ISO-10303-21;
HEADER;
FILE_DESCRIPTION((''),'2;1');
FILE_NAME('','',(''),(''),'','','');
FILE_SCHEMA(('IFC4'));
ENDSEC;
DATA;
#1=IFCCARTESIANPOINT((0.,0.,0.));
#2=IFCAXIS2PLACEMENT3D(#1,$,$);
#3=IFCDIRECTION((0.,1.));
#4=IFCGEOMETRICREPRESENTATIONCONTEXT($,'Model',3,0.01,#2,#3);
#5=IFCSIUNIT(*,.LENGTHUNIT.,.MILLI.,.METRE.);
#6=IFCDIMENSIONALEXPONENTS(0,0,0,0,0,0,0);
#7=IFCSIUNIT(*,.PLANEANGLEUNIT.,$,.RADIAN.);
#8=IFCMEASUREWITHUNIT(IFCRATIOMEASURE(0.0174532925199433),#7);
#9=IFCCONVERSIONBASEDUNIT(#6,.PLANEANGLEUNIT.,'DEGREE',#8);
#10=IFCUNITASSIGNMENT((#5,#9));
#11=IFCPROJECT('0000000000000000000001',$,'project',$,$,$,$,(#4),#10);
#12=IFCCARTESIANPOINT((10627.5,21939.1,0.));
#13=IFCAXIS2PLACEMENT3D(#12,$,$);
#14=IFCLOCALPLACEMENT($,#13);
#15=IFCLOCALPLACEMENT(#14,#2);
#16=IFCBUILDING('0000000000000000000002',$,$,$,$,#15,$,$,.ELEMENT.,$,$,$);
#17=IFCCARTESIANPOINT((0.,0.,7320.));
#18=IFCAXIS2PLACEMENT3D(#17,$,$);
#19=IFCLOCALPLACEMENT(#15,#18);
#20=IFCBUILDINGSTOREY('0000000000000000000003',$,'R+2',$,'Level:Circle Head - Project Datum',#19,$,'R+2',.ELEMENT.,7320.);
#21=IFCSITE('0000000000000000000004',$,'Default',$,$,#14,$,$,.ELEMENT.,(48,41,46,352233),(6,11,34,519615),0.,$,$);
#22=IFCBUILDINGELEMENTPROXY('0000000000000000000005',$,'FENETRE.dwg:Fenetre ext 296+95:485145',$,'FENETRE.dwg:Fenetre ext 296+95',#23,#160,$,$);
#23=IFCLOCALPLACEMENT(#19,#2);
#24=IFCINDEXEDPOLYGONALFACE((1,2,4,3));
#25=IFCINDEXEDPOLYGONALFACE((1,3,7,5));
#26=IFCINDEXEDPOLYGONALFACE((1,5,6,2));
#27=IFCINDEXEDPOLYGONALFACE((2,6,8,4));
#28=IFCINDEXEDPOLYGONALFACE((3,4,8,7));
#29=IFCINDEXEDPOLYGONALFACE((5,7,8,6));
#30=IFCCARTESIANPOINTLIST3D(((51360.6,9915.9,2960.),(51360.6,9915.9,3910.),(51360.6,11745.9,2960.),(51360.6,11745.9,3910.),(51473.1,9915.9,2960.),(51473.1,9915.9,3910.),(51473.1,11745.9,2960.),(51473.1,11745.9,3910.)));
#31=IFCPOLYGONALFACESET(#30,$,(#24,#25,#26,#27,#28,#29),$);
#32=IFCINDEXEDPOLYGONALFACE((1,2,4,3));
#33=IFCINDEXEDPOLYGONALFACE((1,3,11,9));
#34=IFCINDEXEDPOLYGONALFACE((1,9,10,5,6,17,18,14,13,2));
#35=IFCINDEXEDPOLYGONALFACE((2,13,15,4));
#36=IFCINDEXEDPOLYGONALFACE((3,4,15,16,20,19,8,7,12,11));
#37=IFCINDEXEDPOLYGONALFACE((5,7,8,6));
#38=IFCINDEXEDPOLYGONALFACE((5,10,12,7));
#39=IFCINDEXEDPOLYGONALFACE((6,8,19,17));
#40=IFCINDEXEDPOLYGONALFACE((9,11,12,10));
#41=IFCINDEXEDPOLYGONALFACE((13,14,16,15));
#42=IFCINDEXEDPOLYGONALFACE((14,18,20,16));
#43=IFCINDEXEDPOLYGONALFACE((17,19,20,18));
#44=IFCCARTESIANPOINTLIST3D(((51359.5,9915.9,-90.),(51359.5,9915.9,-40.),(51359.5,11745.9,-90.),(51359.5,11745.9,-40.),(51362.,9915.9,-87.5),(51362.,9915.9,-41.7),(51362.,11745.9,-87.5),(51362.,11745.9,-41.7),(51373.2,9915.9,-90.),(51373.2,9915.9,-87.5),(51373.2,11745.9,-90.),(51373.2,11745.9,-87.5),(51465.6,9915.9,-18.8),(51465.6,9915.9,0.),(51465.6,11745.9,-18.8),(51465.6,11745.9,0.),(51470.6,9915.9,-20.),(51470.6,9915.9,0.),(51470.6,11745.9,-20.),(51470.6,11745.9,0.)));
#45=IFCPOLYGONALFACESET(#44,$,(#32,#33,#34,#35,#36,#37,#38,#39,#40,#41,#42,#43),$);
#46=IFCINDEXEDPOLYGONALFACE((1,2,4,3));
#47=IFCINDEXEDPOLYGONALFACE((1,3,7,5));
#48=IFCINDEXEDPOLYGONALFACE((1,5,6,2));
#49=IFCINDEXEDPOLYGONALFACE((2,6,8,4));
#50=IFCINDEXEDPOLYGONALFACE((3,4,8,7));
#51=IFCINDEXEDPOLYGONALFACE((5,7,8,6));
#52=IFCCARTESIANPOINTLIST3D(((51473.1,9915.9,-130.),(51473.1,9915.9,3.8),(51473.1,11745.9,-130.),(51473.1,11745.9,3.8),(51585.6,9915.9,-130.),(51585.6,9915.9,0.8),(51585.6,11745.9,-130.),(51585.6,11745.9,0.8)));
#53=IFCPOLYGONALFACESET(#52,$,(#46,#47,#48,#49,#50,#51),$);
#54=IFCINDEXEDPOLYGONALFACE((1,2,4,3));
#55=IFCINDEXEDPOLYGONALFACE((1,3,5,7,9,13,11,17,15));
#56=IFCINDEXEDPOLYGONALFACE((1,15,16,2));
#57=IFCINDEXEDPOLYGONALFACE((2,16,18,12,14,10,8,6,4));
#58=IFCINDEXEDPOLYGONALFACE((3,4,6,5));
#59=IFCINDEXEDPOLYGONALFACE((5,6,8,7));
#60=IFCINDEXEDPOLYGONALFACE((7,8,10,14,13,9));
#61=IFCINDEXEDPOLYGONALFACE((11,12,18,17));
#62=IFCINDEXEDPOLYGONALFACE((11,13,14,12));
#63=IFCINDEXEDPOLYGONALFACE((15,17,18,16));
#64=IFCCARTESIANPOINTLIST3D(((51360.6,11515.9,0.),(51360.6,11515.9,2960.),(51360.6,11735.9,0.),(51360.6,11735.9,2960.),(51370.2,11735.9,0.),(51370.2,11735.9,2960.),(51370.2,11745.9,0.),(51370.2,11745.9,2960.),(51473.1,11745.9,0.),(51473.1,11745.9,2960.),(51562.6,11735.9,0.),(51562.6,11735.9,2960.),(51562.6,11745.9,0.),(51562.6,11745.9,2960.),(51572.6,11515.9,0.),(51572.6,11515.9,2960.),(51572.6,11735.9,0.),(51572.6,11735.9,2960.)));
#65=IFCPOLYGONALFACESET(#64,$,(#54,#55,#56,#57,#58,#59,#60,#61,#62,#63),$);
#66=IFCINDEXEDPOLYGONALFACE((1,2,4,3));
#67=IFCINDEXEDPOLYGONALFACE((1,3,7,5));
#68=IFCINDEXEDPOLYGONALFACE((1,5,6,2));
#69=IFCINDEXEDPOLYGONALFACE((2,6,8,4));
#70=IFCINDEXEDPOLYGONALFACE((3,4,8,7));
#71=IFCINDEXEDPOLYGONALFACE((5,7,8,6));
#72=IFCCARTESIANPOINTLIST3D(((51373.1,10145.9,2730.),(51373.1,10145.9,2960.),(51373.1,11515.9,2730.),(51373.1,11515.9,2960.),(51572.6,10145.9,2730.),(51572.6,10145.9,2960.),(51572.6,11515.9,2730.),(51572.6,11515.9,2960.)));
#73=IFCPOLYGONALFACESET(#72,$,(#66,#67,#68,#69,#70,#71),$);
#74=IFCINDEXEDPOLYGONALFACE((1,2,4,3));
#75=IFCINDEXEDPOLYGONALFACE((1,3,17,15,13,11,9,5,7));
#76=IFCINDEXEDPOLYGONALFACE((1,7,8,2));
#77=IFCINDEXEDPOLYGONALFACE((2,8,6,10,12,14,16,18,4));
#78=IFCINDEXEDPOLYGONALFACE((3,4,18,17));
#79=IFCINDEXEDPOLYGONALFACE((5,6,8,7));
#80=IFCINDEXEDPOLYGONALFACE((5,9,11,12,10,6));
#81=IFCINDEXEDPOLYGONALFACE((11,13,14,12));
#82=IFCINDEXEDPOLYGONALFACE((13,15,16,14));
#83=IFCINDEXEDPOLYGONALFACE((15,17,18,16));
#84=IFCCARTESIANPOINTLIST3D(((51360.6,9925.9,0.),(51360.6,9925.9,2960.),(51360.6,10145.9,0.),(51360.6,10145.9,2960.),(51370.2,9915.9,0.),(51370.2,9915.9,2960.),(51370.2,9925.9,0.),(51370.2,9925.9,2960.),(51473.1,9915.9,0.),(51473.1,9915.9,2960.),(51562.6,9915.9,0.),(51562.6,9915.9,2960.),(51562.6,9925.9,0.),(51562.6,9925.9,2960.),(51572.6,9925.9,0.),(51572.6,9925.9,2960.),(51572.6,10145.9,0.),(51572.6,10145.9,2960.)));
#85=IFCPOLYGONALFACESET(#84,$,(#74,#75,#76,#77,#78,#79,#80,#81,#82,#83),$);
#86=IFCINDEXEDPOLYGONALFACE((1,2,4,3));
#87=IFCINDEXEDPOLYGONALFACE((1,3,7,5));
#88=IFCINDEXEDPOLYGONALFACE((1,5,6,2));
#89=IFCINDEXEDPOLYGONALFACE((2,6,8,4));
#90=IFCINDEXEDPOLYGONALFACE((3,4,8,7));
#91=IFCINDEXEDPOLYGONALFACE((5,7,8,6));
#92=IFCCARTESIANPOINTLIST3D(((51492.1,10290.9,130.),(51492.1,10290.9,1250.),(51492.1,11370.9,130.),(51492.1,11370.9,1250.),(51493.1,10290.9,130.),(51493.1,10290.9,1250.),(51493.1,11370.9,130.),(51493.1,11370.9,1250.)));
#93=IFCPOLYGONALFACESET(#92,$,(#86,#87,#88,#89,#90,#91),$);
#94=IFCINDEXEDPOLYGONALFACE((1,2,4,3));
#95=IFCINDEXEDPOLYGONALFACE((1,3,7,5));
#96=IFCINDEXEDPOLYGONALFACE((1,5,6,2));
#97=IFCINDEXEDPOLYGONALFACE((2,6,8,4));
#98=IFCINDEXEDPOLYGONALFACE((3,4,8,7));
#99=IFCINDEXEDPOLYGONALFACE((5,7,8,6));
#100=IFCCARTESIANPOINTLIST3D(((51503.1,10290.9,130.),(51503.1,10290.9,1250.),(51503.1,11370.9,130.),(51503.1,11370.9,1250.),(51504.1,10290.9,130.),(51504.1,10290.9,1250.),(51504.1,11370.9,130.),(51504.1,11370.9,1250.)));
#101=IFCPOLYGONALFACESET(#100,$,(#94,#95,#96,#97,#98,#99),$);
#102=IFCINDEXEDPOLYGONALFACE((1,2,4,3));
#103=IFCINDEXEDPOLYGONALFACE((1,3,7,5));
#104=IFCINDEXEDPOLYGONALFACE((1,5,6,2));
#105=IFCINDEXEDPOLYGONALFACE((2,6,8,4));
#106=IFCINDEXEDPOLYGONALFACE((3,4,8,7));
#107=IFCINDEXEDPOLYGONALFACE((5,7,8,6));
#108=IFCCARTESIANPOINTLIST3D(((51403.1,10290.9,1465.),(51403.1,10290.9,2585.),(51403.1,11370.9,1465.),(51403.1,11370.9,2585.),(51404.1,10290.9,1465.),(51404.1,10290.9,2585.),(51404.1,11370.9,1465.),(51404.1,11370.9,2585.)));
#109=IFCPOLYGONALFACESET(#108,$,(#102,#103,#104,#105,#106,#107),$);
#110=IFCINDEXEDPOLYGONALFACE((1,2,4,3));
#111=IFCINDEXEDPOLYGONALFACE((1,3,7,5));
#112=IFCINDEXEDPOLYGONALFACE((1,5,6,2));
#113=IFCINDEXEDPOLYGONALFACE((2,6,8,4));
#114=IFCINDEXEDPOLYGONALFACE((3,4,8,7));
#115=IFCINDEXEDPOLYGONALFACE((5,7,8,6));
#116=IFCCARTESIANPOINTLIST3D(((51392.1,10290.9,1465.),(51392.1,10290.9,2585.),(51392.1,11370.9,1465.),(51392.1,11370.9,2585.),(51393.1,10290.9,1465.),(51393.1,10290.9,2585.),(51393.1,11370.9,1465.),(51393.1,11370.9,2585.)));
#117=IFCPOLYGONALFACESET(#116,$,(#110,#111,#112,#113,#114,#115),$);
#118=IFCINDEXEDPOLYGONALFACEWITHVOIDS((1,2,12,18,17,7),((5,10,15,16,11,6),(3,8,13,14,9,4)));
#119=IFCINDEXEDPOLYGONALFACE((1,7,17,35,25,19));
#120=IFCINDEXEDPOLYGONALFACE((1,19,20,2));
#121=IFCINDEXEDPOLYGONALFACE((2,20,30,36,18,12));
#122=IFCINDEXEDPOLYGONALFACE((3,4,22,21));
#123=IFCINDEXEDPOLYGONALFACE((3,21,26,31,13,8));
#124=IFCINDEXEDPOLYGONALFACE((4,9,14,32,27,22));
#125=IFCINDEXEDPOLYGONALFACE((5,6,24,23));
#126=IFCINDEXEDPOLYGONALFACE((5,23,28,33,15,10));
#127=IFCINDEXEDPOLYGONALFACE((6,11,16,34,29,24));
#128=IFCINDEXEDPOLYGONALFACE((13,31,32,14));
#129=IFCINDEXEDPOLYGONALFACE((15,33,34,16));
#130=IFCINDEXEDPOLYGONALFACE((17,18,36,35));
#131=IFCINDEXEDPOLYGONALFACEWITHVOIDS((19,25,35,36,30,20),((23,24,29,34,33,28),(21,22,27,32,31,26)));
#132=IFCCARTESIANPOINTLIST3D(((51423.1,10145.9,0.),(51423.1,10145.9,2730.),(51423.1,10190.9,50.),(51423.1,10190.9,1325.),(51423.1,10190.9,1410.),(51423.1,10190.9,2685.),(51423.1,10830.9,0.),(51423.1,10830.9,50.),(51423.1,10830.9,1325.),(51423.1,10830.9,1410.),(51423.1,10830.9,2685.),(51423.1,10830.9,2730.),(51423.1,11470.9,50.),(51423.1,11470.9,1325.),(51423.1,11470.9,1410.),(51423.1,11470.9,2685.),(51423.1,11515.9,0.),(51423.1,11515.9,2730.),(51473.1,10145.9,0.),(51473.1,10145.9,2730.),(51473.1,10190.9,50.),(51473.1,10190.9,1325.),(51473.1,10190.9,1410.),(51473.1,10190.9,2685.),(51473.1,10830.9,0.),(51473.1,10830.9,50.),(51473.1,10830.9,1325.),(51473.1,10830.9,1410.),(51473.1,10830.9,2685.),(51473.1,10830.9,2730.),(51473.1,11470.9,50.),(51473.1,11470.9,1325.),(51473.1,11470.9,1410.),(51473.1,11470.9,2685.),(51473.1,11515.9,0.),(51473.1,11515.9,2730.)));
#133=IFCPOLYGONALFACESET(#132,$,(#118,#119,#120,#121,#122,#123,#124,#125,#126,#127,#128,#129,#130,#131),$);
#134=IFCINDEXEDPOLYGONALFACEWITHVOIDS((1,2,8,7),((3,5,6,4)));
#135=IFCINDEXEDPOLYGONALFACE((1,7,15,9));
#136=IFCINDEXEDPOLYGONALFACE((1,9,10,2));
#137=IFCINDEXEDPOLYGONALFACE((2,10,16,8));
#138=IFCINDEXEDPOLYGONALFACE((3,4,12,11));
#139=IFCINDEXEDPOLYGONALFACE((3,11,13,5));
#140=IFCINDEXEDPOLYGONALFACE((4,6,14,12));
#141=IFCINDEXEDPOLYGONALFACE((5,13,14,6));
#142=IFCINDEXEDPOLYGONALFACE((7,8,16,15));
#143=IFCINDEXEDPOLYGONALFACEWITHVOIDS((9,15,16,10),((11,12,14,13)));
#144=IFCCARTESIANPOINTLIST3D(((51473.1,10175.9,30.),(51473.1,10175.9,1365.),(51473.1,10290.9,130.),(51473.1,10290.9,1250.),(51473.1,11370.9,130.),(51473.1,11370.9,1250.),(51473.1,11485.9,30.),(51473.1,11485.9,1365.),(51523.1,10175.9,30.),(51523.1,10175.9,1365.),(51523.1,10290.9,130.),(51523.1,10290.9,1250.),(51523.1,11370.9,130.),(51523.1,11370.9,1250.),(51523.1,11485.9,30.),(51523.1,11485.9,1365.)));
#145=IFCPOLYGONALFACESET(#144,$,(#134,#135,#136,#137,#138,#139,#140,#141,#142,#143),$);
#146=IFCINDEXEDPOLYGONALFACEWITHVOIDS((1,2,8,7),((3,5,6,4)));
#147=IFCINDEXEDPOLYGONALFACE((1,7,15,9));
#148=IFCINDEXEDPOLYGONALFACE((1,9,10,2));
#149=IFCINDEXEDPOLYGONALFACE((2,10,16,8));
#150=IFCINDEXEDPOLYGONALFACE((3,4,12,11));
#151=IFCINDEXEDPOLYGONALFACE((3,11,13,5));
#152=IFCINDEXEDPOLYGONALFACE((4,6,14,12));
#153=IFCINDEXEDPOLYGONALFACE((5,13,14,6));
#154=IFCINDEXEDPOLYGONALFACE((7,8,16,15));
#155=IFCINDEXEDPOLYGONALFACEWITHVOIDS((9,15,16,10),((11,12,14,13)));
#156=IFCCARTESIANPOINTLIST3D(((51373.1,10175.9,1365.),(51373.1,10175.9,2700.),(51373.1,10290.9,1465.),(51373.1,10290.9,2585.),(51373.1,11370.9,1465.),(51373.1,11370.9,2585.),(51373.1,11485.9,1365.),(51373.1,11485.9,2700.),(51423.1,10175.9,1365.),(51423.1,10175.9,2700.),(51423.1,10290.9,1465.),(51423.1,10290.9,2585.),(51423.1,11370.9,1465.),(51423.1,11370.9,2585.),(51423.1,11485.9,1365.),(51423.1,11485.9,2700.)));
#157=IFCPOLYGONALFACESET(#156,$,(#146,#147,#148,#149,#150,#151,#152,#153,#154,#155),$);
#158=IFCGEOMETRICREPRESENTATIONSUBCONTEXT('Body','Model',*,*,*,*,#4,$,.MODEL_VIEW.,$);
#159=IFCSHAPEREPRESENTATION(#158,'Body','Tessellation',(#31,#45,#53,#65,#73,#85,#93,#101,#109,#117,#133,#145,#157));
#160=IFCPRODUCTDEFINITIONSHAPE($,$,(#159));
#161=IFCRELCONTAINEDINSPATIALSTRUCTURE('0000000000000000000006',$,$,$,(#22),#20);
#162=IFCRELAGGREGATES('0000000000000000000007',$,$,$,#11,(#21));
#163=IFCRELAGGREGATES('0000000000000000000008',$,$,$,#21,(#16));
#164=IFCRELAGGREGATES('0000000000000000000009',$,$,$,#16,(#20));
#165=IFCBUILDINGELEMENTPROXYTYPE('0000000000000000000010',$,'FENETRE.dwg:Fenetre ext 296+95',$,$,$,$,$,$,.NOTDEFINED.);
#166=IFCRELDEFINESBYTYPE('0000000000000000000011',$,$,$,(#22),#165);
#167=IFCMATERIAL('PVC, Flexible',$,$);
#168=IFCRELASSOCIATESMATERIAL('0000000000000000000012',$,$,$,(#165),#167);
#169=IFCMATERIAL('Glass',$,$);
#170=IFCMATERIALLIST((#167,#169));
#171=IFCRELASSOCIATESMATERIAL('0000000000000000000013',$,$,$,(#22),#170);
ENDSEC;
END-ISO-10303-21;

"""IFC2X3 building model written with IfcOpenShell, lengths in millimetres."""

from ifc_helpers import new_model, entity, si_unit, converted_unit, direction, frame, frame_2d, origin, origin_2d_with_axis, place, context, subcontext, project, spatial, polyline, rectangle, outline, extrude, source, transform, mapped, material, material_list, type_object, type_shapes, element, save


model = new_model("IFC2X3")

# Units and contexts
model_context = context("Model", 3, precision=0.01, world=origin(), true_north=direction((0.0, 1.0)))
body_context = subcontext(model_context, "Body", "Model", "MODEL_VIEW")
ifc_project = project(units=[si_unit("LENGTHUNIT", "METRE", prefix="MILLI"), converted_unit("PLANEANGLEUNIT", "DEGREE", entity("IfcRatioMeasure", 0.0174532925199433), si_unit("PLANEANGLEUNIT", "RADIAN"), dimensions=[0, 0, 0, 0, 0, 0, 0])], contexts=[model_context])

# Site, building, storey
site_placement = place(None, frame((10627.5, 21939.1, 0.0)))
site = spatial("IfcSite", under=ifc_project, at=site_placement, Name="Default", CompositionType="ELEMENT", RefLatitude=(48, 41, 46, 352233), RefLongitude=(6, 11, 34, 519615), RefElevation=0.0)
building_placement = place(site_placement, origin())
building = spatial("IfcBuilding", under=site, at=building_placement, CompositionType="ELEMENT")
storey_placement = place(building_placement, frame((0.0, 0.0, 7320.0)))
storey = spatial("IfcBuildingStorey", under=building, at=storey_placement, Name="R+2", ObjectType="Level:Circle Head - Project Datum", LongName="R+2", CompositionType="ELEMENT", Elevation=7320.0)

# Building element proxy
ifc_material_1 = material(Name="PVC, Flexible")
ifc_material_2 = material(Name="Glass")
building_element_proxy_type_1 = type_object("IfcBuildingElementProxyType", Name="FENETRE.dwg:Fenetre ext 296+95", PredefinedType="NOTDEFINED", material=ifc_material_1)
shared_shape_1 = source(origin(), body_context, "Body", "SweptSolid", [
    extrude(rectangle(XDim=1830.0, YDim=112.5, at=origin_2d_with_axis()), frame((-10.4, 56.3, 2960.0), z_axis=(0.0, 0.0, 1.0), x_axis=(-1.0, 0.0, 0.0)), (0.0, 0.0, 1.0), 950.0),
    extrude(outline(polyline([(-68.6, -14.4), (-72.5, -34.0), (-67.6, -35.0), (-63.9, -16.6), (44.3, -16.6), (54.1, 32.5), (40.6, 35.2), (40.1, 32.7), (51.2, 30.5), (42.2, -14.4), (-68.6, -14.4)])), frame((-925.4, 66.9, -47.5), z_axis=(-1.0, 0.0, 0.0), x_axis=(0.0, 0.980599, -0.196027)), (0.0, 0.0, -1.0), 1830.0),
    extrude(outline(polyline([(-64.7, -56.3), (66.2, -56.3), (66.2, 56.3), (-67.7, 56.3), (-64.7, -56.3)])), frame((-925.4, -56.3, -63.8), z_axis=(1.0, 0.0, 0.0), x_axis=(0.0, 0.0, -1.0)), (0.0, 0.0, 1.0), 1830.0),
    extrude(outline(polyline([(-55.6, 97.0), (-55.6, -5.9), (-55.6, -95.4), (-45.6, -95.4), (-45.6, -105.4), (174.4, -105.4), (174.4, 106.6), (-45.6, 106.6), (-45.6, 97.0), (-55.6, 97.0)])), frame((849.0, 5.9, 0.0), z_axis=(0.0, 0.0, -1.0), x_axis=(-1.0, 0.0, 0.0)), (0.0, 0.0, -1.0), 2960.0),
    extrude(rectangle(XDim=199.5, YDim=1370.0, at=origin_2d_with_axis()), frame((-10.4, 0.3, 2730.0), z_axis=(0.0, 0.0, 1.0), x_axis=(0.0, 1.0, 0.0)), (0.0, 0.0, 1.0), 230.0),
    extrude(outline(polyline([(-97.0, -55.6), (5.9, -55.6), (95.4, -55.6), (95.4, -45.6), (105.4, -45.6), (105.4, 174.4), (-106.6, 174.4), (-106.6, -45.6), (-97.0, -45.6), (-97.0, -55.6)])), frame((-869.9, 5.9, 0.0), z_axis=(0.0, 0.0, 1.0), x_axis=(0.0, -1.0, 0.0)), (0.0, 0.0, 1.0), 2960.0),
    extrude(rectangle(XDim=1.0, YDim=1080.0, at=origin_2d_with_axis()), frame((-10.4, -19.5, 130.0), z_axis=(0.0, 0.0, 1.0), x_axis=(0.0, 1.0, 0.0)), (0.0, 0.0, 1.0), 1120.0),
    extrude(rectangle(XDim=1.0, YDim=1080.0, at=frame_2d((0.0, 0.0), x_axis=(1.0, 0.0))), frame((-10.4, -30.5, 130.0), z_axis=(0.0, 0.0, 1.0), x_axis=(0.0, 1.0, 0.0)), (0.0, 0.0, 1.0), 1120.0),
    extrude(rectangle(XDim=1.0, YDim=1080.0, at=frame_2d((0.0, 0.0), x_axis=(1.0, 0.0))), frame((-10.4, 69.5, 1465.0), z_axis=(0.0, 0.0, 1.0), x_axis=(0.0, 1.0, 0.0)), (0.0, 0.0, 1.0), 1120.0),
    extrude(rectangle(XDim=1.0, YDim=1080.0, at=frame_2d((0.0, 0.0), x_axis=(1.0, 0.0))), frame((-10.4, 80.5, 1465.0), z_axis=(0.0, 0.0, 1.0), x_axis=(0.0, 1.0, 0.0)), (0.0, 0.0, 1.0), 1120.0),
    extrude(outline(polyline([(-685.0, -1365.0), (0.0, -1365.0), (685.0, -1365.0), (685.0, 1365.0), (0.0, 1365.0), (-685.0, 1365.0), (-685.0, -1365.0)]), holes=[polyline([(-640.0, -1320.0), (-640.0, -45.0), (0.0, -45.0), (640.0, -45.0), (640.0, -1320.0), (0.0, -1320.0), (-640.0, -1320.0)]), polyline([(-640.0, 40.0), (-640.0, 1315.0), (0.0, 1315.0), (640.0, 1315.0), (640.0, 40.0), (0.0, 40.0), (-640.0, 40.0)])]), frame((-10.4, 0.0, 1365.0), z_axis=(0.0, 1.0, 0.0), x_axis=(1.0, 0.0, 0.0)), (0.0, 0.0, 1.0), 50.0),
    extrude(outline(polyline([(-655.0, -667.5), (655.0, -667.5), (655.0, 667.5), (-655.0, 667.5), (-655.0, -667.5)]), holes=[polyline([(-540.0, 552.5), (540.0, 552.5), (540.0, -567.5), (-540.0, -567.5), (-540.0, 552.5)])]), frame((-10.4, -50.0, 697.5), z_axis=(0.0, 1.0, 0.0), x_axis=(-1.0, 0.0, 0.0)), (0.0, 0.0, 1.0), 50.0),
    extrude(outline(polyline([(-655.0, -667.5), (655.0, -667.5), (655.0, 667.5), (-655.0, 667.5), (-655.0, -667.5)]), holes=[polyline([(-540.0, 552.5), (540.0, 552.5), (540.0, -567.5), (-540.0, -567.5), (-540.0, 552.5)])]), frame((-10.4, 50.0, 2032.5), z_axis=(0.0, 1.0, 0.0), x_axis=(-1.0, 0.0, 0.0)), (0.0, 0.0, 1.0), 50.0),
])
type_shapes(building_element_proxy_type_1, [shared_shape_1])
ifc_material_list_1 = material_list([ifc_material_1, ifc_material_2])
proxy_1_placement = place(storey_placement, frame((51473.1, 10841.3, 0.0), z_axis=(0.0, 0.0, 1.0), x_axis=(0.0, 1.0, 0.0)))
element("IfcBuildingElementProxy", 1, at=proxy_1_placement, inside=storey, type_object=building_element_proxy_type_1, material=ifc_material_list_1, Name="FENETRE.dwg:Fenetre ext 296+95:485145", ObjectType="FENETRE.dwg:Fenetre ext 296+95", context=body_context, shape_type="MappedRepresentation", body=[
    mapped(shared_shape_1, transform((0.0, 0.0, 0.0), scale=1.0)),
])

save(model, "model.ifc")
